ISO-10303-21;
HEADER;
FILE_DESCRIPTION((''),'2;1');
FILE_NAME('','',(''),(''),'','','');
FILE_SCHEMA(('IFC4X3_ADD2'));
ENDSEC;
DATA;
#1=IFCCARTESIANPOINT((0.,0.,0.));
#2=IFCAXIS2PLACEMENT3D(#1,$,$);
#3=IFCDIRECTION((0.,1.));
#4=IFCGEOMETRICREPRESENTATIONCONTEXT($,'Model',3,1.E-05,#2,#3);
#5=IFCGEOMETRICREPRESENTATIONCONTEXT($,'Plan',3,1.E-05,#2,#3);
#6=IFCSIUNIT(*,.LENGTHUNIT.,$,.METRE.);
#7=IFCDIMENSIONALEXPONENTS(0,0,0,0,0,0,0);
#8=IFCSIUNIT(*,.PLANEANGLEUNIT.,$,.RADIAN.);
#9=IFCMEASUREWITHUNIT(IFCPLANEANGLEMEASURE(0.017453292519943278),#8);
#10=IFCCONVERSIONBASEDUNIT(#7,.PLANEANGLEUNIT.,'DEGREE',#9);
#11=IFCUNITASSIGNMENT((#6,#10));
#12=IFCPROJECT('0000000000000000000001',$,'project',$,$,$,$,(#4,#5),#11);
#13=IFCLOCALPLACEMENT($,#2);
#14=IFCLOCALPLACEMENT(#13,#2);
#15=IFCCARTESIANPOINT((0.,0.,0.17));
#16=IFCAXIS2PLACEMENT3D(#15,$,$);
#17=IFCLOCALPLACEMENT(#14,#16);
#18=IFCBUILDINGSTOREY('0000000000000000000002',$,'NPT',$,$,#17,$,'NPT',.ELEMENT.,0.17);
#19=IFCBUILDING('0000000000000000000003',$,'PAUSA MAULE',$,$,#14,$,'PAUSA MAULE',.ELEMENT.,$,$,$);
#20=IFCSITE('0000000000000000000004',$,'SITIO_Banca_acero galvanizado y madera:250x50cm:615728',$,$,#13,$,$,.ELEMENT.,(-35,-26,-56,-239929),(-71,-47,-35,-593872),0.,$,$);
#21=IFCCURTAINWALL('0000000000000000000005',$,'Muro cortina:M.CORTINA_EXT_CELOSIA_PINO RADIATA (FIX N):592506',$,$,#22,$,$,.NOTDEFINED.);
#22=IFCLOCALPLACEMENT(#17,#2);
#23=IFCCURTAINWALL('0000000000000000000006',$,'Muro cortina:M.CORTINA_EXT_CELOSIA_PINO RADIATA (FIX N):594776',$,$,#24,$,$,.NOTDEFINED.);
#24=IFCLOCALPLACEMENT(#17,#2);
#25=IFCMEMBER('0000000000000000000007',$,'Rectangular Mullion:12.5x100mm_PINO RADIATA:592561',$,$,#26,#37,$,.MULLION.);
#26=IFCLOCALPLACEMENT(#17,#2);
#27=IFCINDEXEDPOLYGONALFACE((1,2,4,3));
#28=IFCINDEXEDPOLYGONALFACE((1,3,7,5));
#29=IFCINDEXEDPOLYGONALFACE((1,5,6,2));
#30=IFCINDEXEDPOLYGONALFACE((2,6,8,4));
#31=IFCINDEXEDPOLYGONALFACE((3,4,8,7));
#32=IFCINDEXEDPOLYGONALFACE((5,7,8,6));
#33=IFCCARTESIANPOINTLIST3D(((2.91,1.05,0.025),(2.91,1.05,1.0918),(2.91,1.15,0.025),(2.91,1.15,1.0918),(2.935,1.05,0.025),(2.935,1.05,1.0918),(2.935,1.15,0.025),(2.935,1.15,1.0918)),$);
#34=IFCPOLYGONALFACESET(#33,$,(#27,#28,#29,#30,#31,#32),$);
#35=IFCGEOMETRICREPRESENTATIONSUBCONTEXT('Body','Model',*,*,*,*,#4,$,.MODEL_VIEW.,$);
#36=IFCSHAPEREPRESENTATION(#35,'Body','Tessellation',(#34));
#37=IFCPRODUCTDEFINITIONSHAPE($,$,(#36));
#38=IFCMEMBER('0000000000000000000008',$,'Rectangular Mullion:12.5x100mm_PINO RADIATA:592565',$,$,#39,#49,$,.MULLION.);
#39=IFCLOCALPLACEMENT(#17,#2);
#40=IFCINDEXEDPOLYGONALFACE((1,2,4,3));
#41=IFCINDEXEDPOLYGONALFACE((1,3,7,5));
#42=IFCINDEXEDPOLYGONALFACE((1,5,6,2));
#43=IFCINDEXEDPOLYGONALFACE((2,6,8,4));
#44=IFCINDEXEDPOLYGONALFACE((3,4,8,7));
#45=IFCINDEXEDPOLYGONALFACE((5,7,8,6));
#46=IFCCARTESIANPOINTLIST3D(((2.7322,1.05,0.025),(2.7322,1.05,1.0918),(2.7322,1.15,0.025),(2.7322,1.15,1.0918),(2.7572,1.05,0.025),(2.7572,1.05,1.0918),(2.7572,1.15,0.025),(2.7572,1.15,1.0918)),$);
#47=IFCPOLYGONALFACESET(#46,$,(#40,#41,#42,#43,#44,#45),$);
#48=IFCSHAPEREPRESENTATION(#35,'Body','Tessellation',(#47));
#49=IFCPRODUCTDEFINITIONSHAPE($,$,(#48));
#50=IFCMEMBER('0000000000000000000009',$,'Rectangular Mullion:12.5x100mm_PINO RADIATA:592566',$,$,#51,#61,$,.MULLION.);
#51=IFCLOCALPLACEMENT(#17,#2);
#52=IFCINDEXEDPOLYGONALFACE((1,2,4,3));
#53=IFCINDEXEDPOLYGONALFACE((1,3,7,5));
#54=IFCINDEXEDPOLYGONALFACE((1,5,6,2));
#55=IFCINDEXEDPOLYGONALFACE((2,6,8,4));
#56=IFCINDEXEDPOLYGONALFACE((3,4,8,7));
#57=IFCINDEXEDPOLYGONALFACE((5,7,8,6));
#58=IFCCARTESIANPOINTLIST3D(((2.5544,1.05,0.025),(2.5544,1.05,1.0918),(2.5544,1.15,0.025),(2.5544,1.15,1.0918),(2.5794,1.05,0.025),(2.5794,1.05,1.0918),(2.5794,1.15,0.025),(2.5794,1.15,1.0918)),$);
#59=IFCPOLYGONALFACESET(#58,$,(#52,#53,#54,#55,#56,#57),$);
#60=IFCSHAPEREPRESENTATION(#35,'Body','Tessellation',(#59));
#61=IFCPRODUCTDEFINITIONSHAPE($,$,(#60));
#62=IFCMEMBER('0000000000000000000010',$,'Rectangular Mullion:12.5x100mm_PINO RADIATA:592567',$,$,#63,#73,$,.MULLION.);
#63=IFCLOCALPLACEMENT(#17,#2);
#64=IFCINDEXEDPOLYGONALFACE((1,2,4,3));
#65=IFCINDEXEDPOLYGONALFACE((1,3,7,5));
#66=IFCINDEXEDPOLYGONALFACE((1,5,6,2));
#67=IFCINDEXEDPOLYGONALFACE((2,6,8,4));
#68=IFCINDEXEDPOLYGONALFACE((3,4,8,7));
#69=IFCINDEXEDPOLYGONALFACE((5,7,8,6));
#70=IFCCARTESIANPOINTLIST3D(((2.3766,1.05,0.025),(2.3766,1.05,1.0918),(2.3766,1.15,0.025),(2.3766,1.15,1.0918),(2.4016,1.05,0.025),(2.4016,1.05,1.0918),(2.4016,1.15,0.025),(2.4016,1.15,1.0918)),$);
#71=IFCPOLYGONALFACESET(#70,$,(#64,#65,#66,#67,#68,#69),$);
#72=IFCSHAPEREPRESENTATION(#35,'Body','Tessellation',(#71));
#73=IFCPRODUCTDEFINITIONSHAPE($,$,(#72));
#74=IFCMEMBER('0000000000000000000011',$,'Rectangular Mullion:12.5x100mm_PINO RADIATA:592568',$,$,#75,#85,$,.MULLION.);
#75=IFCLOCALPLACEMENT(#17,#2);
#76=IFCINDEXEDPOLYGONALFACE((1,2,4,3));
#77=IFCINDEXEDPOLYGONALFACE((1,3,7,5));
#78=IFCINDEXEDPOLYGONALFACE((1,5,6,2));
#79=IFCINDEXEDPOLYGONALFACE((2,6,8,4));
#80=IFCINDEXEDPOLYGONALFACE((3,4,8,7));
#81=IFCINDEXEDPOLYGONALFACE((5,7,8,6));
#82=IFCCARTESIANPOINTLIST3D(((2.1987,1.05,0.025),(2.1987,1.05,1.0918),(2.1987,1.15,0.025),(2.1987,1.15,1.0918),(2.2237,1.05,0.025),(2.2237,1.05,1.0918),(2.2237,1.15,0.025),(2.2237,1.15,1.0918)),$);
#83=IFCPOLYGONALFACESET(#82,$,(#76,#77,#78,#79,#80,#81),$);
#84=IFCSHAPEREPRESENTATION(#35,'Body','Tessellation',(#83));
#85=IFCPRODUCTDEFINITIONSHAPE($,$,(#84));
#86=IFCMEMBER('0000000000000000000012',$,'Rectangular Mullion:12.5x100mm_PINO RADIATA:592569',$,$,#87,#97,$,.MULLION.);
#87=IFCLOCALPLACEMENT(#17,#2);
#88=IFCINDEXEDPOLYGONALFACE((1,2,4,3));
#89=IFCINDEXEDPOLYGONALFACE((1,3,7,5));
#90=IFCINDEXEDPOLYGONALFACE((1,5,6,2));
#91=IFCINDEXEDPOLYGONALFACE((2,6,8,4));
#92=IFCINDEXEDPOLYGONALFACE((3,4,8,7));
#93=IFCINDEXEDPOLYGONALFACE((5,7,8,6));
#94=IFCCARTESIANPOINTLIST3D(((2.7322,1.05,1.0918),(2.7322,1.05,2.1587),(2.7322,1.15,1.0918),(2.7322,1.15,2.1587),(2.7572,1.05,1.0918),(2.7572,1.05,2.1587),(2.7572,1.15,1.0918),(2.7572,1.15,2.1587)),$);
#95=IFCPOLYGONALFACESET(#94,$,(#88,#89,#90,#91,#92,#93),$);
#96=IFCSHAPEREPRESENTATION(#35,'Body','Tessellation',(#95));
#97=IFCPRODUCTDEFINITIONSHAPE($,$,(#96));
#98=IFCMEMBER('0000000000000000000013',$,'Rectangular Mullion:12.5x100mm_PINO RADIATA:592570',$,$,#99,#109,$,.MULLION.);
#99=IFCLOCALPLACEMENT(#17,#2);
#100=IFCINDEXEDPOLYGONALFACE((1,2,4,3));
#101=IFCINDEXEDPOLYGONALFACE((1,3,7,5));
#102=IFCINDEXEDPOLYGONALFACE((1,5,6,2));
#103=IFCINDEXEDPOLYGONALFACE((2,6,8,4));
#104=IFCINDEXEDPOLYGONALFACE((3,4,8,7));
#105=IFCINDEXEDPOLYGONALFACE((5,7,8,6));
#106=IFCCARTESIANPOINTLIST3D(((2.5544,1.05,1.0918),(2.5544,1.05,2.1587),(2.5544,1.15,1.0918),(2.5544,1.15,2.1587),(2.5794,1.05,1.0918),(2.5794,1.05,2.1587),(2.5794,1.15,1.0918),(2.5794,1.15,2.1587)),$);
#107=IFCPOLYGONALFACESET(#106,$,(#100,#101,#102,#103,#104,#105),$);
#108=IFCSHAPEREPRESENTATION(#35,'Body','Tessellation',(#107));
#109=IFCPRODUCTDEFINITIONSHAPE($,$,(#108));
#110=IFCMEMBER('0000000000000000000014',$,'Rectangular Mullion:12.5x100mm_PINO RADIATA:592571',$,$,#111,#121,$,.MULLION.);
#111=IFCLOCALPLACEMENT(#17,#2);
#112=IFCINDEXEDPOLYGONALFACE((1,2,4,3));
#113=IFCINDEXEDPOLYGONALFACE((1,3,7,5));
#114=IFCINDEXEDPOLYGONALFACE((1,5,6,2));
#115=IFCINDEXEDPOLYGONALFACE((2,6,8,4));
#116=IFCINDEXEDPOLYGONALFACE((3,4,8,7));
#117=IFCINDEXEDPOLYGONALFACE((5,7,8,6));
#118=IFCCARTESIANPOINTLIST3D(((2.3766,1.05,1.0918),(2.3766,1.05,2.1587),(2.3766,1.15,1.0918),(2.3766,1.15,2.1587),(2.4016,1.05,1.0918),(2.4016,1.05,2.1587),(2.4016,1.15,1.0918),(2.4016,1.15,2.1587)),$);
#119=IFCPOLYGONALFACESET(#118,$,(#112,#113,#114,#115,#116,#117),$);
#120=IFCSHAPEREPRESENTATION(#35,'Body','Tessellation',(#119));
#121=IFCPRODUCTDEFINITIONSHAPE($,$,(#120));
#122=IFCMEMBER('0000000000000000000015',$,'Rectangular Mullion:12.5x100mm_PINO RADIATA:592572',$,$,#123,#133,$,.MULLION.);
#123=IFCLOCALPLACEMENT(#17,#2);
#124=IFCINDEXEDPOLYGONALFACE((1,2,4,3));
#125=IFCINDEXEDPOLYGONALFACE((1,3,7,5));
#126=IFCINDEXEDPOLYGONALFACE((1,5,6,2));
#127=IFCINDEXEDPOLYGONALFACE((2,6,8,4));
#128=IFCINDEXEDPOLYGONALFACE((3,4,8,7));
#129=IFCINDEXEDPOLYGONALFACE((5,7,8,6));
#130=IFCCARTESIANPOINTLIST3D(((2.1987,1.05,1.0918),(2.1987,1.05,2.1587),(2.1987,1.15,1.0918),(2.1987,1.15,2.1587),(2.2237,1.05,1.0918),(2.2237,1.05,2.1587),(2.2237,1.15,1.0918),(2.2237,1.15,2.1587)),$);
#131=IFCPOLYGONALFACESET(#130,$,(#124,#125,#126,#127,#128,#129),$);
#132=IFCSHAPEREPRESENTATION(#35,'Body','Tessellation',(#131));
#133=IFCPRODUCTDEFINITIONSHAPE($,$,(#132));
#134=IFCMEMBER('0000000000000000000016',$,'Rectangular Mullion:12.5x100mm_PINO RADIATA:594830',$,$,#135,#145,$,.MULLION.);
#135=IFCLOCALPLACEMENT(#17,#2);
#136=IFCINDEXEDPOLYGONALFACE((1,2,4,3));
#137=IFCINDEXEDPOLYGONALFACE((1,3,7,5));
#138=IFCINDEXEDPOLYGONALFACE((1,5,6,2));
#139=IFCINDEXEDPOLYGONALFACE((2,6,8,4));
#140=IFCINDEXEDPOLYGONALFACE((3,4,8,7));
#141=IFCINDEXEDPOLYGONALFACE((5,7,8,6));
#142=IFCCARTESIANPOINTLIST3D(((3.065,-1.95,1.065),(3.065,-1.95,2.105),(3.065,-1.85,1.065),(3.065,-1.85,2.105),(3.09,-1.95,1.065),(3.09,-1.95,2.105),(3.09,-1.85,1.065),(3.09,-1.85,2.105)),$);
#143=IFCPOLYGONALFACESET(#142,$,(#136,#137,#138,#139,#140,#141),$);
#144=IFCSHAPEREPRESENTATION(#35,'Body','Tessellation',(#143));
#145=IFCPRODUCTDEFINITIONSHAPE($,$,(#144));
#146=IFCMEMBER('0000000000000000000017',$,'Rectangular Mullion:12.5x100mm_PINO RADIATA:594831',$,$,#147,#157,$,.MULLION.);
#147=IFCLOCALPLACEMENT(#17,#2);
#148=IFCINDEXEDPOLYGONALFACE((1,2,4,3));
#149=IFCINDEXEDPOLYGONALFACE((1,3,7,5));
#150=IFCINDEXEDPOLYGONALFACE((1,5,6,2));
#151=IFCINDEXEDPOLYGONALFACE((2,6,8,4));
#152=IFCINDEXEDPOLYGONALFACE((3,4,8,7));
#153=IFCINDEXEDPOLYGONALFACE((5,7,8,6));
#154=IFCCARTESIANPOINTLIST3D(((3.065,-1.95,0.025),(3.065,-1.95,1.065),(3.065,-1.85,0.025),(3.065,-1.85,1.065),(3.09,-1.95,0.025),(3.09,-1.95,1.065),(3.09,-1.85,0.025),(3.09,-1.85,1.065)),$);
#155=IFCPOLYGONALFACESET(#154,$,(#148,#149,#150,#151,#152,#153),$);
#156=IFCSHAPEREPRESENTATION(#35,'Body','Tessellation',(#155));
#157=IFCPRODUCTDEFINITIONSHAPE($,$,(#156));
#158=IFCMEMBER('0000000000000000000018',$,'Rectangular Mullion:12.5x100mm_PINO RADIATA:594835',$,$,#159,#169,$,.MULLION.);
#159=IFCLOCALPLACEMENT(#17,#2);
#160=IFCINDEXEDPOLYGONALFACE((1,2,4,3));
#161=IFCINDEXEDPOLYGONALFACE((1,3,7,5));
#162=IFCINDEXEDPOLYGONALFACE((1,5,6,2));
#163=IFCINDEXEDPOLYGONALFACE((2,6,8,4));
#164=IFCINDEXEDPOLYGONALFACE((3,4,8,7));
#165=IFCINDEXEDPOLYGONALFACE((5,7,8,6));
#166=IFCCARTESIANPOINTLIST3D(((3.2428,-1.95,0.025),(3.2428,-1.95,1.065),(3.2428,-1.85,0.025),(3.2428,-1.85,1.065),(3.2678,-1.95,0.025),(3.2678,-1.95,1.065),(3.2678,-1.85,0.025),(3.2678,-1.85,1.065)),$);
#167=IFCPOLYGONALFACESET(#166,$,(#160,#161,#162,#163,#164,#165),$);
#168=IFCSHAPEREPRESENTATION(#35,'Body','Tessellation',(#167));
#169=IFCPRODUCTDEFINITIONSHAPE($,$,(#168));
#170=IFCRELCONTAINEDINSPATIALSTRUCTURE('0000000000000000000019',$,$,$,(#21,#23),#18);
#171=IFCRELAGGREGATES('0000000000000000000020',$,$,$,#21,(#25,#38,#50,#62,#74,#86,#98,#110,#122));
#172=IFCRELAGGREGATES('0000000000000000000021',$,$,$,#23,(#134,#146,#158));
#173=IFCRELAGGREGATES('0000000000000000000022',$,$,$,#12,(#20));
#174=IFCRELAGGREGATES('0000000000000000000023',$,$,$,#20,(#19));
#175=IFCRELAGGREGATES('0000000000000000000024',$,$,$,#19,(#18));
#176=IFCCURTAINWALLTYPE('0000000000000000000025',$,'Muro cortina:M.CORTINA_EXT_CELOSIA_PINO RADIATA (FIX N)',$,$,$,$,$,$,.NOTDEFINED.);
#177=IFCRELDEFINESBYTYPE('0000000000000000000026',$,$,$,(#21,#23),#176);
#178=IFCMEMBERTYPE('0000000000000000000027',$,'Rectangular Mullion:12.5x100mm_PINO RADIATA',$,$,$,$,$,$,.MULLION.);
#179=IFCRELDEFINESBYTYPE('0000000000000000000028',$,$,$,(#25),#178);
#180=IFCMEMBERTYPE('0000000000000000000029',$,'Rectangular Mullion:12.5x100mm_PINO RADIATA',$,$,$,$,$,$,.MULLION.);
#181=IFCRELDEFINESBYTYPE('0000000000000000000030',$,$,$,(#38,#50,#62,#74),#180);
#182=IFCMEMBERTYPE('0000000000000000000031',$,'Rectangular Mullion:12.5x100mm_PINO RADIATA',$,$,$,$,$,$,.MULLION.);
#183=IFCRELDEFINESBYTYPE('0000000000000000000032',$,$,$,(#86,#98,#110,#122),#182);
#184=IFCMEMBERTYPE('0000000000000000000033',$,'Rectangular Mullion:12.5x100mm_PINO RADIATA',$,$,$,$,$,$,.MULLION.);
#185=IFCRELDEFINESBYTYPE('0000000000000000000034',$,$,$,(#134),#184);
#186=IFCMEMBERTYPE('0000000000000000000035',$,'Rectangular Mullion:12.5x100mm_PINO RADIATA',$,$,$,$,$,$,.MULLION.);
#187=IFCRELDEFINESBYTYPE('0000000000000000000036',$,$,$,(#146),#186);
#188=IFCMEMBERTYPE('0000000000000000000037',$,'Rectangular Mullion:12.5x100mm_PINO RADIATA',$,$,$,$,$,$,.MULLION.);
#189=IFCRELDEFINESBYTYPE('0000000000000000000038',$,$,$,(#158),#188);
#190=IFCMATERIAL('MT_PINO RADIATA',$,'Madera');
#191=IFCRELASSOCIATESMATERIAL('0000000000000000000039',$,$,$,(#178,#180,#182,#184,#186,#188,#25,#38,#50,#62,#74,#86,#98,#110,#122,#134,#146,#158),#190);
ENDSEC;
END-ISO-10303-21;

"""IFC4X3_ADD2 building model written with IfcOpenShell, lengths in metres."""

from ifc_helpers import new_model, entity, si_unit, converted_unit, direction, frame, frame_2d, origin, origin_2d_with_axis, place, context, subcontext, project, spatial, rectangle, extrude, source, transform, mapped, material, material_profile, profile_set, profile_usage, type_object, type_shapes, element, aggregate, save


model = new_model("IFC4X3_ADD2")

# Units and contexts
model_context = context("Model", 3, precision=1e-05, world=origin(), true_north=direction((0.0, 1.0)))
plan_context = context("Plan", 3, precision=1e-05, world=origin(), true_north=direction((0.0, 1.0)))
body_context = subcontext(model_context, "Body", "Model", "MODEL_VIEW")
ifc_project = project(units=[si_unit("LENGTHUNIT", "METRE"), converted_unit("PLANEANGLEUNIT", "DEGREE", entity("IfcPlaneAngleMeasure", 0.017453292519943278), si_unit("PLANEANGLEUNIT", "RADIAN"), dimensions=[0, 0, 0, 0, 0, 0, 0])], contexts=[model_context, plan_context])

# Site, building, storey
site_placement = place(None, origin())
site = spatial("IfcSite", under=ifc_project, at=site_placement, Name="SITIO_Banca_acero galvanizado y madera:250x50cm:615728", CompositionType="ELEMENT", RefLatitude=(-35, -26, -56, -239929), RefLongitude=(-71, -47, -35, -593872), RefElevation=0.0)
building_placement = place(site_placement, origin())
building = spatial("IfcBuilding", under=site, at=building_placement, Name="PAUSA MAULE", LongName="PAUSA MAULE", CompositionType="ELEMENT")
storey_placement = place(building_placement, frame((0.0, 0.0, 0.17)))
storey = spatial("IfcBuildingStorey", under=building, at=storey_placement, Name="NPT", LongName="NPT", CompositionType="ELEMENT", Elevation=0.17)

# Curtain walls
curtain_wall_type = type_object("IfcCurtainWallType", Name="Muro cortina:M.CORTINA_EXT_CELOSIA_PINO RADIATA (FIX N)", PredefinedType="NOTDEFINED")
curtain_wall_1_placement = place(storey_placement, frame((0.0, 0.0, -0.17)))
curtain_wall_1 = element("IfcCurtainWall", 1, at=curtain_wall_1_placement, inside=storey, type_object=curtain_wall_type, Name="Muro cortina:M.CORTINA_EXT_CELOSIA_PINO RADIATA (FIX N):592506", PredefinedType="NOTDEFINED")
ifc_material = material(Name="MT_PINO RADIATA", Category="Madera")
ifc_material_profile = material_profile(ifc_material, rectangle(XDim=0.025, YDim=0.1, at=frame_2d((0.0, 0.0), x_axis=(1.0, 0.0))), Name="12.5x100mm_PINO RADIATA")
ifc_profile_set = profile_set([ifc_material_profile], Name="12.5x100mm_PINO RADIATA")
ifc_profile_usage = profile_usage(ifc_profile_set)
curtain_wall_2_placement = place(storey_placement, frame((0.0, 0.0, -0.17)))
curtain_wall_2 = element("IfcCurtainWall", 2, at=curtain_wall_2_placement, inside=storey, type_object=curtain_wall_type, Name="Muro cortina:M.CORTINA_EXT_CELOSIA_PINO RADIATA (FIX N):594776", PredefinedType="NOTDEFINED")

# Members
member_type_1 = type_object("IfcMemberType", Name="Rectangular Mullion:12.5x100mm_PINO RADIATA", PredefinedType="MULLION", material=ifc_profile_set)
shared_shape_1 = source(origin(), body_context, "Body", "SweptSolid", [
    extrude(rectangle(XDim=0.025, YDim=0.1, at=frame_2d((0.0, 0.0), x_axis=(1.0, 0.0))), frame((-0.0125, 0.0, -1.0668), z_axis=(0.0, 0.0, 1.0), x_axis=(-1.0, 0.0, 0.0)), (0.0, 0.0, 1.0), 1.0668),
])
type_shapes(member_type_1, [shared_shape_1])
member_1_placement = place(curtain_wall_1_placement, frame((2.935, 1.1, 1.2618)))
member_1 = element("IfcMember", 3, at=member_1_placement, type_object=member_type_1, material=ifc_profile_usage, Name="Rectangular Mullion:12.5x100mm_PINO RADIATA:592561", PredefinedType="MULLION", context=body_context, shape_type="MappedRepresentation", body=[
    mapped(shared_shape_1, transform((0.0, 0.0, 0.0), scale=1.0)),
])
member_type_2 = type_object("IfcMemberType", Name="Rectangular Mullion:12.5x100mm_PINO RADIATA", PredefinedType="MULLION", material=ifc_profile_set)
shared_shape_2 = source(origin(), body_context, "Body", "SweptSolid", [
    extrude(rectangle(XDim=0.025, YDim=0.1, at=origin_2d_with_axis()), frame((0.0, 0.0, -1.0668), z_axis=(0.0, 0.0, 1.0), x_axis=(-1.0, 0.0, 0.0)), (0.0, 0.0, 1.0), 1.0668),
])
type_shapes(member_type_2, [shared_shape_2])
member_2_placement = place(curtain_wall_1_placement, frame((2.7447, 1.1, 0.195), z_axis=(0.0, 0.0, -1.0), x_axis=(-1.0, 0.0, 0.0)))
member_2 = element("IfcMember", 4, at=member_2_placement, type_object=member_type_2, material=ifc_profile_usage, Name="Rectangular Mullion:12.5x100mm_PINO RADIATA:592565", PredefinedType="MULLION", context=body_context, shape_type="MappedRepresentation", body=[
    mapped(shared_shape_2, transform((0.0, 0.0, 0.0), scale=1.0)),
])
member_3_placement = place(curtain_wall_1_placement, frame((2.5669, 1.1, 0.195), z_axis=(0.0, 0.0, -1.0), x_axis=(-1.0, 0.0, 0.0)))
member_3 = element("IfcMember", 5, at=member_3_placement, type_object=member_type_2, material=ifc_profile_usage, Name="Rectangular Mullion:12.5x100mm_PINO RADIATA:592566", PredefinedType="MULLION", context=body_context, shape_type="MappedRepresentation", body=[
    mapped(shared_shape_2, transform((0.0, 0.0, 0.0), scale=1.0)),
])
member_4_placement = place(curtain_wall_1_placement, frame((2.3891, 1.1, 0.195), z_axis=(0.0, 0.0, -1.0), x_axis=(-1.0, 0.0, 0.0)))
member_4 = element("IfcMember", 6, at=member_4_placement, type_object=member_type_2, material=ifc_profile_usage, Name="Rectangular Mullion:12.5x100mm_PINO RADIATA:592567", PredefinedType="MULLION", context=body_context, shape_type="MappedRepresentation", body=[
    mapped(shared_shape_2, transform((0.0, 0.0, 0.0), scale=1.0)),
])
member_5_placement = place(curtain_wall_1_placement, frame((2.2112, 1.1, 0.195), z_axis=(0.0, 0.0, -1.0), x_axis=(-1.0, 0.0, 0.0)))
member_5 = element("IfcMember", 7, at=member_5_placement, type_object=member_type_2, material=ifc_profile_usage, Name="Rectangular Mullion:12.5x100mm_PINO RADIATA:592568", PredefinedType="MULLION", context=body_context, shape_type="MappedRepresentation", body=[
    mapped(shared_shape_2, transform((0.0, 0.0, 0.0), scale=1.0)),
])
member_type_3 = type_object("IfcMemberType", Name="Rectangular Mullion:12.5x100mm_PINO RADIATA", PredefinedType="MULLION", material=ifc_profile_set)
shared_shape_3 = source(origin(), body_context, "Body", "SweptSolid", [
    extrude(rectangle(XDim=0.025, YDim=0.1, at=origin_2d_with_axis()), frame((0.0, 0.0, -1.0668), z_axis=(0.0, 0.0, 1.0), x_axis=(-1.0, 0.0, 0.0)), (0.0, 0.0, 1.0), 1.0668),
])
type_shapes(member_type_3, [shared_shape_3])
member_6_placement = place(curtain_wall_1_placement, frame((2.7447, 1.1, 1.2618), z_axis=(0.0, 0.0, -1.0), x_axis=(-1.0, 0.0, 0.0)))
member_6 = element("IfcMember", 8, at=member_6_placement, type_object=member_type_3, material=ifc_profile_usage, Name="Rectangular Mullion:12.5x100mm_PINO RADIATA:592569", PredefinedType="MULLION", context=body_context, shape_type="MappedRepresentation", body=[
    mapped(shared_shape_3, transform((0.0, 0.0, 0.0), scale=1.0)),
])
member_7_placement = place(curtain_wall_1_placement, frame((2.5669, 1.1, 1.2618), z_axis=(0.0, 0.0, -1.0), x_axis=(-1.0, 0.0, 0.0)))
member_7 = element("IfcMember", 9, at=member_7_placement, type_object=member_type_3, material=ifc_profile_usage, Name="Rectangular Mullion:12.5x100mm_PINO RADIATA:592570", PredefinedType="MULLION", context=body_context, shape_type="MappedRepresentation", body=[
    mapped(shared_shape_3, transform((0.0, 0.0, 0.0), scale=1.0)),
])
member_8_placement = place(curtain_wall_1_placement, frame((2.3891, 1.1, 1.2618), z_axis=(0.0, 0.0, -1.0), x_axis=(-1.0, 0.0, 0.0)))
member_8 = element("IfcMember", 10, at=member_8_placement, type_object=member_type_3, material=ifc_profile_usage, Name="Rectangular Mullion:12.5x100mm_PINO RADIATA:592571", PredefinedType="MULLION", context=body_context, shape_type="MappedRepresentation", body=[
    mapped(shared_shape_3, transform((0.0, 0.0, 0.0), scale=1.0)),
])
member_9_placement = place(curtain_wall_1_placement, frame((2.2112, 1.1, 1.2618), z_axis=(0.0, 0.0, -1.0), x_axis=(-1.0, 0.0, 0.0)))
member_9 = element("IfcMember", 11, at=member_9_placement, type_object=member_type_3, material=ifc_profile_usage, Name="Rectangular Mullion:12.5x100mm_PINO RADIATA:592572", PredefinedType="MULLION", context=body_context, shape_type="MappedRepresentation", body=[
    mapped(shared_shape_3, transform((0.0, 0.0, 0.0), scale=1.0)),
])
aggregate(curtain_wall_1, [member_1, member_2, member_3, member_4, member_5, member_6, member_7, member_8, member_9])
member_type_4 = type_object("IfcMemberType", Name="Rectangular Mullion:12.5x100mm_PINO RADIATA", PredefinedType="MULLION", material=ifc_profile_set)
shared_shape_4 = source(origin(), body_context, "Body", "SweptSolid", [
    extrude(rectangle(XDim=0.025, YDim=0.1, at=origin_2d_with_axis()), frame((-0.0125, 0.0, -1.04), z_axis=(0.0, 0.0, 1.0), x_axis=(-1.0, 0.0, 0.0)), (0.0, 0.0, 1.0), 1.04),
])
type_shapes(member_type_4, [shared_shape_4])
member_10_placement = place(curtain_wall_2_placement, frame((3.065, -1.9, 2.275), z_axis=(0.0, 0.0, 1.0), x_axis=(-1.0, 0.0, 0.0)))
member_10 = element("IfcMember", 12, at=member_10_placement, type_object=member_type_4, material=ifc_profile_usage, Name="Rectangular Mullion:12.5x100mm_PINO RADIATA:594830", PredefinedType="MULLION", context=body_context, shape_type="MappedRepresentation", body=[
    mapped(shared_shape_4, transform((0.0, 0.0, 0.0), scale=1.0)),
])
member_type_5 = type_object("IfcMemberType", Name="Rectangular Mullion:12.5x100mm_PINO RADIATA", PredefinedType="MULLION", material=ifc_profile_set)
shared_shape_5 = source(origin(), body_context, "Body", "SweptSolid", [
    extrude(rectangle(XDim=0.025, YDim=0.1, at=origin_2d_with_axis()), frame((-0.0125, 0.0, -1.04), z_axis=(0.0, 0.0, 1.0), x_axis=(-1.0, 0.0, 0.0)), (0.0, 0.0, 1.0), 1.04),
])
type_shapes(member_type_5, [shared_shape_5])
member_11_placement = place(curtain_wall_2_placement, frame((3.065, -1.9, 1.235), z_axis=(0.0, 0.0, 1.0), x_axis=(-1.0, 0.0, 0.0)))
member_11 = element("IfcMember", 13, at=member_11_placement, type_object=member_type_5, material=ifc_profile_usage, Name="Rectangular Mullion:12.5x100mm_PINO RADIATA:594831", PredefinedType="MULLION", context=body_context, shape_type="MappedRepresentation", body=[
    mapped(shared_shape_5, transform((0.0, 0.0, 0.0), scale=1.0)),
])
member_type_6 = type_object("IfcMemberType", Name="Rectangular Mullion:12.5x100mm_PINO RADIATA", PredefinedType="MULLION", material=ifc_profile_set)
shared_shape_6 = source(origin(), body_context, "Body", "SweptSolid", [
    extrude(rectangle(XDim=0.025, YDim=0.1, at=frame_2d((0.0, 0.0), x_axis=(1.0, 0.0))), frame((0.0, 0.0, -1.04), z_axis=(0.0, 0.0, 1.0), x_axis=(-1.0, 0.0, 0.0)), (0.0, 0.0, 1.0), 1.04),
])
type_shapes(member_type_6, [shared_shape_6])
member_12_placement = place(curtain_wall_2_placement, frame((3.2553, -1.9, 0.195), z_axis=(0.0, 0.0, -1.0), x_axis=(1.0, 0.0, 0.0)))
member_12 = element("IfcMember", 14, at=member_12_placement, type_object=member_type_6, material=ifc_profile_usage, Name="Rectangular Mullion:12.5x100mm_PINO RADIATA:594835", PredefinedType="MULLION", context=body_context, shape_type="MappedRepresentation", body=[
    mapped(shared_shape_6, transform((0.0, 0.0, 0.0), scale=1.0)),
])
aggregate(curtain_wall_2, [member_10, member_11, member_12])

save(model, "model.ifc")
